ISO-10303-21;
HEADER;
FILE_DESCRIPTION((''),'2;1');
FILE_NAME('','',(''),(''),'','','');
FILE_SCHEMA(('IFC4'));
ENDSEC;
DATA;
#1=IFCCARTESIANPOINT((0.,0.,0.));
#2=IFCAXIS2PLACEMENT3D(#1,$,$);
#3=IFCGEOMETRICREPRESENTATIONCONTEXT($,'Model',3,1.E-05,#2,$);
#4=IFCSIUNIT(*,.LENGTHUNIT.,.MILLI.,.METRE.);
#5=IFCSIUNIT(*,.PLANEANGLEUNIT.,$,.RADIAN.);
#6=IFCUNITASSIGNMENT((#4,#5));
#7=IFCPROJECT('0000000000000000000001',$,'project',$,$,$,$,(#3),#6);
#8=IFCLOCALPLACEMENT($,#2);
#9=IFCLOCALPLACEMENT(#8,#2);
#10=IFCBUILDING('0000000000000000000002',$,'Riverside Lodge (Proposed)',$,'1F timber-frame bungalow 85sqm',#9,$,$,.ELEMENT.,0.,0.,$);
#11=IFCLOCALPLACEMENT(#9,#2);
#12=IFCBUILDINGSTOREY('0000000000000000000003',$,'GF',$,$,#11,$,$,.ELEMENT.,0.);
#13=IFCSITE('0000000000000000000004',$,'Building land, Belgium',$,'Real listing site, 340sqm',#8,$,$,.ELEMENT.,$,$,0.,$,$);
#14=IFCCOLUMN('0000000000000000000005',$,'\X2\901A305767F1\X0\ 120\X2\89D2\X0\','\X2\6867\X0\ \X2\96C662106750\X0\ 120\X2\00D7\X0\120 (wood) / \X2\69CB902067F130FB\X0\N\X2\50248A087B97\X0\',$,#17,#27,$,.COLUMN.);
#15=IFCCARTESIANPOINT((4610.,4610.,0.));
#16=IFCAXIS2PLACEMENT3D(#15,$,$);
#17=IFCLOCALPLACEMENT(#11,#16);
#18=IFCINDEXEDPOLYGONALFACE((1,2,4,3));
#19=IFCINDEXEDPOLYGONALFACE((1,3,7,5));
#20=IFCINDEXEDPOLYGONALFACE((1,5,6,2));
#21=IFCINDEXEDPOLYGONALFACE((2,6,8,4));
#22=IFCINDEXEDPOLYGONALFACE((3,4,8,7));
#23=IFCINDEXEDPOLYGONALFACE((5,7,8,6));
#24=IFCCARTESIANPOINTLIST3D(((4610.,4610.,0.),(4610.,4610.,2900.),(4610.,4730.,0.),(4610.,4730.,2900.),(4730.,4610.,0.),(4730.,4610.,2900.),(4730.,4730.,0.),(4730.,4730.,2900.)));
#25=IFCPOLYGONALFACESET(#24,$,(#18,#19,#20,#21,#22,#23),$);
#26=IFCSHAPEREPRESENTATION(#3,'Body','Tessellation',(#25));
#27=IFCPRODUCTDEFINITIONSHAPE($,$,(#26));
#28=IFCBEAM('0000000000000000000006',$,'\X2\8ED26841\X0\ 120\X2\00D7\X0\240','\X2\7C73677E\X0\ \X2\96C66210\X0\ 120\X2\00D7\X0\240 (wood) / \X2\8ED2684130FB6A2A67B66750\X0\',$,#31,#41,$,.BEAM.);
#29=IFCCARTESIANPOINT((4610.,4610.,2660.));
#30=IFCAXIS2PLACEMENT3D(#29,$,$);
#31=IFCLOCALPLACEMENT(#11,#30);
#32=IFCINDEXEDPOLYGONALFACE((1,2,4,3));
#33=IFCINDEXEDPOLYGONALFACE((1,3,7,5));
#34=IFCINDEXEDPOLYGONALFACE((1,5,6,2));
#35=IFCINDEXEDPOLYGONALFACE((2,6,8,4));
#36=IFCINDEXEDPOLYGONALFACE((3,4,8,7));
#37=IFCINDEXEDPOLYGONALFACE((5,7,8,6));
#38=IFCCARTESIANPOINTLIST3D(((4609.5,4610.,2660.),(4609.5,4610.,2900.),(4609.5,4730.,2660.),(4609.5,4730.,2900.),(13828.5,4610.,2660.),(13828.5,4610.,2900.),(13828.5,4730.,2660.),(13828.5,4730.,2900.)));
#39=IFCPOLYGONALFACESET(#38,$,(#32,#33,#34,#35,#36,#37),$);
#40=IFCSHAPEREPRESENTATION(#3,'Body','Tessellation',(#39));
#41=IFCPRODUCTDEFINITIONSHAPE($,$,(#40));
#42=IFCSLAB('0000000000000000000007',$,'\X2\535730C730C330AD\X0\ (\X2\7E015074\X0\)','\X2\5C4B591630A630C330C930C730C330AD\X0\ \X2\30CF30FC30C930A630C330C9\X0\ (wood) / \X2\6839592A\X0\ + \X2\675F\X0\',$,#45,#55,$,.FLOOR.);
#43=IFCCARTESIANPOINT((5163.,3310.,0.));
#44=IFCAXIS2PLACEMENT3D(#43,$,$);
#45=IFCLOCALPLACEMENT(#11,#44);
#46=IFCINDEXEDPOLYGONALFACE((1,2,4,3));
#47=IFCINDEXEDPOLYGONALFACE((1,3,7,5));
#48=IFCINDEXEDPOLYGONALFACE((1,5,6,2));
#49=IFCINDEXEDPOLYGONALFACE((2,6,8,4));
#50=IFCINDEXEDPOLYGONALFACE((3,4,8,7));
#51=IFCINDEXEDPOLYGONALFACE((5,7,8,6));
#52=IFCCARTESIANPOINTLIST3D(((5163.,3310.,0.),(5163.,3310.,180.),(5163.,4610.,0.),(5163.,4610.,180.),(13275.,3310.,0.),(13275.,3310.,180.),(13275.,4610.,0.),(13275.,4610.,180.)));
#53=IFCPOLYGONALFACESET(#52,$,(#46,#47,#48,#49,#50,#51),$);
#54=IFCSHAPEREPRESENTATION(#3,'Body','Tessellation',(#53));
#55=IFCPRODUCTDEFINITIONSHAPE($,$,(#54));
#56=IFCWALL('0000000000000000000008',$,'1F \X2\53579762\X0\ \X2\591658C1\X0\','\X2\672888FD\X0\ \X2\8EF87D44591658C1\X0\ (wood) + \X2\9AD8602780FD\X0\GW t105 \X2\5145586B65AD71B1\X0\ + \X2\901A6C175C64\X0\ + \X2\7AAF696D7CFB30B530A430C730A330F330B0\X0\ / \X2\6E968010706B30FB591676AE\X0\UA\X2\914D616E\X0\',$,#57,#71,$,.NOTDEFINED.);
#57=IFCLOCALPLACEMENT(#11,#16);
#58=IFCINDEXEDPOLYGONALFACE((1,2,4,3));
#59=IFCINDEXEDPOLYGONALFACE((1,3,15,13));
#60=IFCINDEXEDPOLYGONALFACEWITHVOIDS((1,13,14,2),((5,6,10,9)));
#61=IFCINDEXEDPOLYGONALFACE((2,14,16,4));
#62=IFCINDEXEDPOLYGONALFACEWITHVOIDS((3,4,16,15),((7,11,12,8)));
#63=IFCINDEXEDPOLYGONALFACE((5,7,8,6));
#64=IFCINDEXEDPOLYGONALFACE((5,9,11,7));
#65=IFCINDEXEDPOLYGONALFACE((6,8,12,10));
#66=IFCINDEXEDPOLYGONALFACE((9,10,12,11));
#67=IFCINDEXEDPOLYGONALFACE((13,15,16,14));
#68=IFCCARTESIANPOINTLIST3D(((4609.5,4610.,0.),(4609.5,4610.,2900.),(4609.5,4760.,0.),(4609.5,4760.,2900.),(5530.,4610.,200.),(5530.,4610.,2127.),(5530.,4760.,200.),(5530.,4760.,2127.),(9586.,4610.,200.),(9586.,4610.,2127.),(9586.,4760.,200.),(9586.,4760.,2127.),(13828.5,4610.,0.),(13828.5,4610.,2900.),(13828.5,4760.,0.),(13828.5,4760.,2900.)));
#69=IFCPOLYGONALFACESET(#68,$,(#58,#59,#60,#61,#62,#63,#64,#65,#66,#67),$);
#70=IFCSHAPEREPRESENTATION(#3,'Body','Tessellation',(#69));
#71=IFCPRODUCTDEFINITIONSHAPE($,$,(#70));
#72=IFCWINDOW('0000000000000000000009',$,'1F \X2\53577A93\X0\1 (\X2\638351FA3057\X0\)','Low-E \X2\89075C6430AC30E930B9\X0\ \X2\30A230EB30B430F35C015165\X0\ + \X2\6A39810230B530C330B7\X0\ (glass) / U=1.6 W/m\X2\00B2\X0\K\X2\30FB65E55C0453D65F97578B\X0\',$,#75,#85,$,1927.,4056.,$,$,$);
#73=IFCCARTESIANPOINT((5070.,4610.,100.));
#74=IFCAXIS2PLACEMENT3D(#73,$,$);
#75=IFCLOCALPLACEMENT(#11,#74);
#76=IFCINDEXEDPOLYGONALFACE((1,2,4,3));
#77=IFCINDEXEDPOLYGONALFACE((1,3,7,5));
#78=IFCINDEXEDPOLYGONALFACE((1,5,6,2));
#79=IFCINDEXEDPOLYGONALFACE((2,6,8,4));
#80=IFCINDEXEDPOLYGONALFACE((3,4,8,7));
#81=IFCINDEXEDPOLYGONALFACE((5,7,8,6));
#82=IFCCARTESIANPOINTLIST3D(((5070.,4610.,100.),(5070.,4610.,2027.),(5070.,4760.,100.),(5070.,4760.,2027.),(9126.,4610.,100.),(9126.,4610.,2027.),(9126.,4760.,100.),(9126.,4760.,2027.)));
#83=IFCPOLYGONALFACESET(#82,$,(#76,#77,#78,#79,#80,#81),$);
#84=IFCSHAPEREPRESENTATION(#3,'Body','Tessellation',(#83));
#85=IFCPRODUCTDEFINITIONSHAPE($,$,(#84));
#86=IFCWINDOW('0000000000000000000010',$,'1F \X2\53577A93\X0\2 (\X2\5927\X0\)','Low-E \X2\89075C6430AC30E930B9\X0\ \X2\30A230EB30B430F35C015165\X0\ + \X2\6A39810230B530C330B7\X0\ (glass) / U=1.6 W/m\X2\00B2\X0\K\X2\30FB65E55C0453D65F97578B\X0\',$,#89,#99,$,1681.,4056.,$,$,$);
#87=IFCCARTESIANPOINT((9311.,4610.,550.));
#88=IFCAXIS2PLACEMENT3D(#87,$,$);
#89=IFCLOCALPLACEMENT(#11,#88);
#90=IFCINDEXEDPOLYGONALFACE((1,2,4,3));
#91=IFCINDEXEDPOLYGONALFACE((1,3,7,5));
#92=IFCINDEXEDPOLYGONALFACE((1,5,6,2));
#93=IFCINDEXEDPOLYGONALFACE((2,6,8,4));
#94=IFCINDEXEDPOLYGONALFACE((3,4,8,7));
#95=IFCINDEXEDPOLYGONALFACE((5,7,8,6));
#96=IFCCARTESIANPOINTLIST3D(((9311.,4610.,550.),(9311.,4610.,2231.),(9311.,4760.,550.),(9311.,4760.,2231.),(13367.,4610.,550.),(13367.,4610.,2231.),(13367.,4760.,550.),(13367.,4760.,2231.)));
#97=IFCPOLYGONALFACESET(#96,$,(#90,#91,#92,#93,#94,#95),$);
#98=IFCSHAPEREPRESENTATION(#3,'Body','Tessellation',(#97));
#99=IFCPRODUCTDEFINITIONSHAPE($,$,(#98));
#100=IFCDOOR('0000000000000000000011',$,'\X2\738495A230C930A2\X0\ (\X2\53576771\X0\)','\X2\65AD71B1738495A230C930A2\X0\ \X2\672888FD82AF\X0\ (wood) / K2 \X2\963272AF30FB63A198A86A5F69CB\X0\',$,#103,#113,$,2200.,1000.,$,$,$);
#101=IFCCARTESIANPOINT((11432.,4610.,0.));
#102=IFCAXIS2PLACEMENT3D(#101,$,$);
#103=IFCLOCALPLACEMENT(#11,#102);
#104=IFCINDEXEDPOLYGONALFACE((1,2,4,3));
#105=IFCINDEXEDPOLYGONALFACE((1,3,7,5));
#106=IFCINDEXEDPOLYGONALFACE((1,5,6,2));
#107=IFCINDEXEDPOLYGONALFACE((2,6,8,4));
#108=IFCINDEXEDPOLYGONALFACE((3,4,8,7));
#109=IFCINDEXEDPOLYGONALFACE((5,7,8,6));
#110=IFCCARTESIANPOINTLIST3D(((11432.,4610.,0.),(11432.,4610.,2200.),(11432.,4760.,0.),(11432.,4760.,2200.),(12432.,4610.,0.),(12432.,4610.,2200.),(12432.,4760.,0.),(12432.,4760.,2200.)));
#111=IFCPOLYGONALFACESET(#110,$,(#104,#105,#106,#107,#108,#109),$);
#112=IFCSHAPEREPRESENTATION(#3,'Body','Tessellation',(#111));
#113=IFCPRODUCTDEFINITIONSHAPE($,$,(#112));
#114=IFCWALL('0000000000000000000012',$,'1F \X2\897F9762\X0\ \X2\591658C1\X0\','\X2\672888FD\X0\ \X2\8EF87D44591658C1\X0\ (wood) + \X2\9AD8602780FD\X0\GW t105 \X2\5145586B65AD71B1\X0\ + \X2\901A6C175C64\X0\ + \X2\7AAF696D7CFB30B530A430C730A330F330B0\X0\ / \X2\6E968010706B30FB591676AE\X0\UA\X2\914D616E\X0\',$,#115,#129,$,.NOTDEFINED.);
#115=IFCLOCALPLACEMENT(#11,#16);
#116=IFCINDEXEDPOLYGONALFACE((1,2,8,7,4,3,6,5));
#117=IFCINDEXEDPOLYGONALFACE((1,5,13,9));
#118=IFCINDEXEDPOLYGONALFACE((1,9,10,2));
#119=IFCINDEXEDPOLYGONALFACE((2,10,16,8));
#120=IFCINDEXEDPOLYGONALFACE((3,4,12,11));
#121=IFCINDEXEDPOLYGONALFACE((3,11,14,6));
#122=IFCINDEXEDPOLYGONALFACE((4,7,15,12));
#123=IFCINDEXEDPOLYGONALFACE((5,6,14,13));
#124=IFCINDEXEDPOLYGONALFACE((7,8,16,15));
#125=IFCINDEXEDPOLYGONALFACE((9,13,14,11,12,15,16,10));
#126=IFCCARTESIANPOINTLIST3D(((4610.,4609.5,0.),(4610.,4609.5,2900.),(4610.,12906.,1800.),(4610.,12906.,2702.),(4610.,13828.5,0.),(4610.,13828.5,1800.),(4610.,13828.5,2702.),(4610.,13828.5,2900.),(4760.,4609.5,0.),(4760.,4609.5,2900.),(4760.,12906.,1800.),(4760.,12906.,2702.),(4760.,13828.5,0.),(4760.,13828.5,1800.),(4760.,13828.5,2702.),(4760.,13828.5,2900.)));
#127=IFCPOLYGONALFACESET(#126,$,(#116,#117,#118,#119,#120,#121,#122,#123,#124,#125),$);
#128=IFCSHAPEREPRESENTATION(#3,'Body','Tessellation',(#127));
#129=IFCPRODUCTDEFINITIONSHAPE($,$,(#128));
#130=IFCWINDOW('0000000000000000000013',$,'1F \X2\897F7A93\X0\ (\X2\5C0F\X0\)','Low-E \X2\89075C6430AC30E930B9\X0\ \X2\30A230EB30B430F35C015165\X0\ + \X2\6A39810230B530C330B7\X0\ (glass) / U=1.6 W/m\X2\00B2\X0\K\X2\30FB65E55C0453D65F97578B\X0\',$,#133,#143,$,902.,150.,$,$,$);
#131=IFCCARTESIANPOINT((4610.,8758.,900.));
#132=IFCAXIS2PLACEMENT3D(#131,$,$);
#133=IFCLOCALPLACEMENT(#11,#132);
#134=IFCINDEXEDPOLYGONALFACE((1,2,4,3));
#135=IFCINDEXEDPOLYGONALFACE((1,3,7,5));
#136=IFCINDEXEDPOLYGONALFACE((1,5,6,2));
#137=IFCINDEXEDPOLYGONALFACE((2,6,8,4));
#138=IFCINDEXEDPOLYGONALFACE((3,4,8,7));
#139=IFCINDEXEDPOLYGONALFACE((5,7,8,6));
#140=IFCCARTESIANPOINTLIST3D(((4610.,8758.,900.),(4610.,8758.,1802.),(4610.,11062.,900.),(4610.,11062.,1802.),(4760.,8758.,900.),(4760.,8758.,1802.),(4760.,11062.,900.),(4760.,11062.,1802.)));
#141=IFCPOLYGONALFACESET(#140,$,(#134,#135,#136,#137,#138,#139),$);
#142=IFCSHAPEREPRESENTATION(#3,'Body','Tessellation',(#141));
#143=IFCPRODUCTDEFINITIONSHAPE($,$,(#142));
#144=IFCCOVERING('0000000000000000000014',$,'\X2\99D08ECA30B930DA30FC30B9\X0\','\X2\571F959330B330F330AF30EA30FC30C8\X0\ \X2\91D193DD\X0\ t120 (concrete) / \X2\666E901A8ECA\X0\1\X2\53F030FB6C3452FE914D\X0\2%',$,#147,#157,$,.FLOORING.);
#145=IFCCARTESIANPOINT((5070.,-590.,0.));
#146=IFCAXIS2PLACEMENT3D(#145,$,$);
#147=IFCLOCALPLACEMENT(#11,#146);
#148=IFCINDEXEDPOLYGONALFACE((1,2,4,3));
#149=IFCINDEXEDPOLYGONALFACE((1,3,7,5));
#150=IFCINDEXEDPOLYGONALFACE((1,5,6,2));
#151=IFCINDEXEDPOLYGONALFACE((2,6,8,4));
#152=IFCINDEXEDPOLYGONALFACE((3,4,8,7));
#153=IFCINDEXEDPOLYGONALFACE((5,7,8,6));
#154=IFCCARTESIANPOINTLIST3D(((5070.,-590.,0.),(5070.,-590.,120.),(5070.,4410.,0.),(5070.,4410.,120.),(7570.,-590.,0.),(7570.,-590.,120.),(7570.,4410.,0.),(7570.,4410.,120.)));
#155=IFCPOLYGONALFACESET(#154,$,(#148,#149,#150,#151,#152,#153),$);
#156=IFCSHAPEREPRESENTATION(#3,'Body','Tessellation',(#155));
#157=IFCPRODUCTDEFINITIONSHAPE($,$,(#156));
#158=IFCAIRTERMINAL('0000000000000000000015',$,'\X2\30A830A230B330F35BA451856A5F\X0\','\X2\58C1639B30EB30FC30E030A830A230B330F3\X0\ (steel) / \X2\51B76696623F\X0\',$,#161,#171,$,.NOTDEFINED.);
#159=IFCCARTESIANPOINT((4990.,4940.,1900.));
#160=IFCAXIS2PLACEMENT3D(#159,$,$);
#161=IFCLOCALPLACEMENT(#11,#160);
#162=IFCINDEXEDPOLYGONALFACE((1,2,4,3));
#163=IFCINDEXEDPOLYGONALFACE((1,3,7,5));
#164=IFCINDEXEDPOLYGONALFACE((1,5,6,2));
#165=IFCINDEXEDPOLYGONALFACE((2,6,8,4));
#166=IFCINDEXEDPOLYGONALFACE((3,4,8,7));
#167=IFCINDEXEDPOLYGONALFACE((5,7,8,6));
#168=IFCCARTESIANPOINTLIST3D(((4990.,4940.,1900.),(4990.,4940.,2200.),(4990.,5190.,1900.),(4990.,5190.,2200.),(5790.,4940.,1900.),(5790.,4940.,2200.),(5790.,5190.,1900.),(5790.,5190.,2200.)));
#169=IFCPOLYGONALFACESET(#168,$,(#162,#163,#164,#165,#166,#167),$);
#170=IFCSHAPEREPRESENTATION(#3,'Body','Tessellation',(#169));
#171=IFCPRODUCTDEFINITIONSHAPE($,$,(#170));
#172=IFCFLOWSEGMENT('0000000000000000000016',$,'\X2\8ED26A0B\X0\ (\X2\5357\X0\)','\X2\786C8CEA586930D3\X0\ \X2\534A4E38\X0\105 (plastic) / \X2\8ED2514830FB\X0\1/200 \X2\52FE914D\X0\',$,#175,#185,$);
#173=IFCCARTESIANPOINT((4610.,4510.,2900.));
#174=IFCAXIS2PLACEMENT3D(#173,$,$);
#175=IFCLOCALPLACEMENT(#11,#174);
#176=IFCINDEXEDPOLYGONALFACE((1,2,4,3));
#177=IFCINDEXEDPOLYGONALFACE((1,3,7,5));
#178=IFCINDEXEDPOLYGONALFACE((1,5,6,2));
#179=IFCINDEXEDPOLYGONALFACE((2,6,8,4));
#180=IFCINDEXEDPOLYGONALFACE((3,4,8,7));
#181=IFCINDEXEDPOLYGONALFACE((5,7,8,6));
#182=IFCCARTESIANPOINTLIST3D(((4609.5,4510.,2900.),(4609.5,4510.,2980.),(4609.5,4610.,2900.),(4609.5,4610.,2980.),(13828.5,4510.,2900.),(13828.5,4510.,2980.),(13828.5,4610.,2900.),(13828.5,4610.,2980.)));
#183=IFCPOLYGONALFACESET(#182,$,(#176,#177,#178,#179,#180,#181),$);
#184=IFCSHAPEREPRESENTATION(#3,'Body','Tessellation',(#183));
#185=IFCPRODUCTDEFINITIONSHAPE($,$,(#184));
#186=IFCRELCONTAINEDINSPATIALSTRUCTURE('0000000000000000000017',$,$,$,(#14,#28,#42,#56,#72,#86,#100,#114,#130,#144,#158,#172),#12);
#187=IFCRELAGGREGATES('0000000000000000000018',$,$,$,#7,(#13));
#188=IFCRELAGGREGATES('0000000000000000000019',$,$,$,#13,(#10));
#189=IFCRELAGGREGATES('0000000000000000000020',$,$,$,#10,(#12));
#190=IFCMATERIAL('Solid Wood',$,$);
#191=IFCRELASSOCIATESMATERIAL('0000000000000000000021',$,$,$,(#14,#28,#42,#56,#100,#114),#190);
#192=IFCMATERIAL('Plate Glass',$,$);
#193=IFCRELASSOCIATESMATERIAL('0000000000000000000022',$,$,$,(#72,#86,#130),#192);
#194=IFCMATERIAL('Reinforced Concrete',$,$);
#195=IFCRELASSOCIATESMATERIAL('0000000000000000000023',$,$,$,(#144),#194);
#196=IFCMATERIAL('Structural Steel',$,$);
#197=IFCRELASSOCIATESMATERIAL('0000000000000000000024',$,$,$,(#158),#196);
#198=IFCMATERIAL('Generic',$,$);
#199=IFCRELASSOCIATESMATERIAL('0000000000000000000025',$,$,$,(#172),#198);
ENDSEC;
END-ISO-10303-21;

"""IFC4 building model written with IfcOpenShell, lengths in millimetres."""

from ifc_helpers import new_model, si_unit, frame, frame_2d, origin, place, context, project, spatial, rectangle, extrude, material, element, fill, save


model = new_model("IFC4")

# Units and contexts
model_context = context("Model", 3, precision=1e-05, world=origin())
ifc_project = project(units=[si_unit("LENGTHUNIT", "METRE", prefix="MILLI"), si_unit("PLANEANGLEUNIT", "RADIAN")], contexts=[model_context])

# Site, building, storey
site_placement = place(None, origin())
site = spatial("IfcSite", under=ifc_project, at=site_placement, Name="Building land, Belgium", ObjectType="Real listing site, 340sqm", CompositionType="ELEMENT", RefElevation=0.0)
building_placement = place(site_placement, origin())
building = spatial("IfcBuilding", under=site, at=building_placement, Name="Riverside Lodge (Proposed)", ObjectType="1F timber-frame bungalow 85sqm", CompositionType="ELEMENT", ElevationOfRefHeight=0.0, ElevationOfTerrain=0.0)
storey_placement = place(building_placement, origin())
storey = spatial("IfcBuildingStorey", under=building, at=storey_placement, Name="GF", CompositionType="ELEMENT", Elevation=0.0)

# Column
ifc_material_1 = material(Name="Solid Wood")
column_1_placement = place(storey_placement, frame((4610.0, 4610.0, 0.0)))
element("IfcColumn", 1, at=column_1_placement, inside=storey, material=ifc_material_1, Name="通し柱 120角", Description="桧 集成材 120×120 (wood) / 構造柱・N値計算", PredefinedType="COLUMN", context=model_context, shape_type="SweptSolid", body=[
    extrude(rectangle(XDim=120.0, YDim=120.0, at=frame_2d((60.0, 60.0))), frame((4610.0, 4610.0, 0.0)), (0.0, 0.0, 1.0), 2900.0),
])

# Beam
beam_1_placement = place(storey_placement, frame((4610.0, 4610.0, 2660.0)))
element("IfcBeam", 2, at=beam_1_placement, inside=storey, material=ifc_material_1, Name="軒桁 120×240", Description="米松 集成 120×240 (wood) / 軒桁・横架材", PredefinedType="BEAM", context=model_context, shape_type="SweptSolid", body=[
    extrude(rectangle(XDim=9219.0, YDim=120.0, at=frame_2d((4609.0, 60.0))), frame((4610.0, 4610.0, 2660.0)), (0.0, 0.0, 1.0), 240.0),
])

# Slab
ifc_material_2 = material(Name="Reinforced Concrete")
slab_1_placement = place(storey_placement, frame((5163.0, 3310.0, 0.0)))
element("IfcSlab", 3, at=slab_1_placement, inside=storey, material=ifc_material_1, Name="南デッキ (縁側)", Description="屋外ウッドデッキ ハードウッド (wood) / 根太 + 束", PredefinedType="FLOOR", context=model_context, shape_type="SweptSolid", body=[
    extrude(rectangle(XDim=8112.0, YDim=1300.0, at=frame_2d((4056.0, 650.0))), frame((5163.0, 3310.0, 0.0)), (0.0, 0.0, 1.0), 180.0),
])

# Wall, openings, windows, door
wall_1_placement = place(storey_placement, frame((4610.0, 4610.0, 0.0)))
wall_1 = element("IfcWall", 4, at=wall_1_placement, inside=storey, material=ifc_material_1, Name="1F 南面 外壁", Description="木製 軸組外壁 (wood) + 高性能GW t105 充填断熱 + 通気層 + 窯業系サイディング / 準耐火・外皮UA配慮", PredefinedType="NOTDEFINED", context=model_context, shape_type="SweptSolid", body=[
    extrude(rectangle(XDim=9219.0, YDim=150.0, at=frame_2d((4609.0, 75.0))), frame((4610.0, 4610.0, 0.0)), (0.0, 0.0, 1.0), 2900.0),
])
opening_1_placement = place(storey_placement, frame((5070.0, 4610.0, 100.0)))
opening_1 = element("IfcOpeningElement", 5, at=opening_1_placement, cuts=wall_1, PredefinedType="NOTDEFINED", context=model_context, shape_type="SweptSolid", body=[
    extrude(rectangle(XDim=4056.0, YDim=150.0, at=frame_2d((2028.0, 75.0))), frame((5070.0, 4610.0, 100.0)), (0.0, 0.0, 1.0), 1927.0),
])
opening_2_placement = place(storey_placement, frame((9311.0, 4610.0, 550.0)))
opening_2 = element("IfcOpeningElement", 6, at=opening_2_placement, cuts=wall_1, PredefinedType="NOTDEFINED", context=model_context, shape_type="SweptSolid", body=[
    extrude(rectangle(XDim=4056.0, YDim=150.0, at=frame_2d((2028.0, 75.0))), frame((9311.0, 4610.0, 550.0)), (0.0, 0.0, 1.0), 1681.0),
])
opening_3_placement = place(storey_placement, frame((11432.0, 4610.0, 0.0)))
opening_3 = element("IfcOpeningElement", 7, at=opening_3_placement, cuts=wall_1, PredefinedType="NOTDEFINED", context=model_context, shape_type="SweptSolid", body=[
    extrude(rectangle(XDim=1000.0, YDim=150.0, at=frame_2d((500.0, 75.0))), frame((11432.0, 4610.0, 0.0)), (0.0, 0.0, 1.0), 2200.0),
])
ifc_material_3 = material(Name="Plate Glass")
window_1_placement = place(storey_placement, frame((5070.0, 4610.0, 100.0)))
window_1 = element("IfcWindow", 8, at=window_1_placement, inside=storey, material=ifc_material_3, Name="1F 南窓1 (掃出し)", Description="Low-E 複層ガラス アルゴン封入 + 樹脂サッシ (glass) / U=1.6 W/m²K・日射取得型", OverallHeight=1927.0, OverallWidth=4056.0, context=model_context, shape_type="SweptSolid", body=[
    extrude(rectangle(XDim=4056.0, YDim=150.0, at=frame_2d((2028.0, 75.0))), frame((5070.0, 4610.0, 100.0)), (0.0, 0.0, 1.0), 1927.0),
])
fill(opening_1, window_1)
window_2_placement = place(storey_placement, frame((9311.0, 4610.0, 550.0)))
window_2 = element("IfcWindow", 9, at=window_2_placement, inside=storey, material=ifc_material_3, Name="1F 南窓2 (大)", Description="Low-E 複層ガラス アルゴン封入 + 樹脂サッシ (glass) / U=1.6 W/m²K・日射取得型", OverallHeight=1681.0, OverallWidth=4056.0, context=model_context, shape_type="SweptSolid", body=[
    extrude(rectangle(XDim=4056.0, YDim=150.0, at=frame_2d((2028.0, 75.0))), frame((9311.0, 4610.0, 550.0)), (0.0, 0.0, 1.0), 1681.0),
])
fill(opening_2, window_2)
door_placement = place(storey_placement, frame((11432.0, 4610.0, 0.0)))
door = element("IfcDoor", 10, at=door_placement, inside=storey, material=ifc_material_1, Name="玄関ドア (南東)", Description="断熱玄関ドア 木製芯 (wood) / K2 防犯・採風機構", OverallHeight=2200.0, OverallWidth=1000.0, context=model_context, shape_type="SweptSolid", body=[
    extrude(rectangle(XDim=1000.0, YDim=150.0, at=frame_2d((500.0, 75.0))), frame((11432.0, 4610.0, 0.0)), (0.0, 0.0, 1.0), 2200.0),
])
fill(opening_3, door)

# Wall, opening, window
wall_2_placement = place(storey_placement, frame((4610.0, 4610.0, 0.0)))
wall_2 = element("IfcWall", 11, at=wall_2_placement, inside=storey, material=ifc_material_1, Name="1F 西面 外壁", Description="木製 軸組外壁 (wood) + 高性能GW t105 充填断熱 + 通気層 + 窯業系サイディング / 準耐火・外皮UA配慮", PredefinedType="NOTDEFINED", context=model_context, shape_type="SweptSolid", body=[
    extrude(rectangle(XDim=150.0, YDim=9219.0, at=frame_2d((75.0, 4609.0))), frame((4610.0, 4610.0, 0.0)), (0.0, 0.0, 1.0), 2900.0),
])
opening_4_placement = place(storey_placement, frame((4610.0, 8758.0, 900.0)))
opening_4 = element("IfcOpeningElement", 12, at=opening_4_placement, cuts=wall_2, PredefinedType="NOTDEFINED", context=model_context, shape_type="SweptSolid", body=[
    extrude(rectangle(XDim=150.0, YDim=2304.0, at=frame_2d((75.0, 1152.0))), frame((4610.0, 8758.0, 900.0)), (0.0, 0.0, 1.0), 902.0),
])
window_3_placement = place(storey_placement, frame((4610.0, 8758.0, 900.0)))
window_3 = element("IfcWindow", 13, at=window_3_placement, inside=storey, material=ifc_material_3, Name="1F 西窓 (小)", Description="Low-E 複層ガラス アルゴン封入 + 樹脂サッシ (glass) / U=1.6 W/m²K・日射取得型", OverallHeight=902.0, OverallWidth=150.0, context=model_context, shape_type="SweptSolid", body=[
    extrude(rectangle(XDim=150.0, YDim=2304.0, at=frame_2d((75.0, 1152.0))), frame((4610.0, 8758.0, 900.0)), (0.0, 0.0, 1.0), 902.0),
])
fill(opening_4, window_3)

# Shared definitions
ifc_material_4 = material(Name="Structural Steel")

# Covering
ifc_material_5 = material(Name="Generic")
covering_1_placement = place(storey_placement, frame((5070.0, -590.0, 0.0)))
element("IfcCovering", 14, at=covering_1_placement, inside=storey, material=ifc_material_2, Name="駐車スペース", Description="土間コンクリート 金鏝 t120 (concrete) / 普通車1台・水勾配2%", PredefinedType="FLOORING", context=model_context, shape_type="SweptSolid", body=[
    extrude(rectangle(XDim=2500.0, YDim=5000.0, at=frame_2d((1250.0, 2500.0))), frame((5070.0, -590.0, 0.0)), (0.0, 0.0, 1.0), 120.0),
])

# Air terminal
air_terminal_placement = place(storey_placement, frame((4990.0, 4940.0, 1900.0)))
element("IfcAirTerminal", 15, at=air_terminal_placement, inside=storey, material=ifc_material_4, Name="エアコン室内機", Description="壁掛ルームエアコン (steel) / 冷暖房", PredefinedType="NOTDEFINED", context=model_context, shape_type="SweptSolid", body=[
    extrude(rectangle(XDim=800.0, YDim=250.0, at=frame_2d((400.0, 125.0))), frame((4990.0, 4940.0, 1900.0)), (0.0, 0.0, 1.0), 300.0),
])

# Flow segment
flow_segment_1_placement = place(storey_placement, frame((4610.0, 4510.0, 2900.0)))
element("IfcFlowSegment", 16, at=flow_segment_1_placement, inside=storey, material=ifc_material_5, Name="軒樋 (南)", Description="硬質塩ビ 半丸105 (plastic) / 軒先・1/200 勾配", context=model_context, shape_type="SweptSolid", body=[
    extrude(rectangle(XDim=9219.0, YDim=100.0, at=frame_2d((4609.0, 50.0))), frame((4610.0, 4510.0, 2900.0)), (0.0, 0.0, 1.0), 80.0),
])

save(model, "model.ifc")
